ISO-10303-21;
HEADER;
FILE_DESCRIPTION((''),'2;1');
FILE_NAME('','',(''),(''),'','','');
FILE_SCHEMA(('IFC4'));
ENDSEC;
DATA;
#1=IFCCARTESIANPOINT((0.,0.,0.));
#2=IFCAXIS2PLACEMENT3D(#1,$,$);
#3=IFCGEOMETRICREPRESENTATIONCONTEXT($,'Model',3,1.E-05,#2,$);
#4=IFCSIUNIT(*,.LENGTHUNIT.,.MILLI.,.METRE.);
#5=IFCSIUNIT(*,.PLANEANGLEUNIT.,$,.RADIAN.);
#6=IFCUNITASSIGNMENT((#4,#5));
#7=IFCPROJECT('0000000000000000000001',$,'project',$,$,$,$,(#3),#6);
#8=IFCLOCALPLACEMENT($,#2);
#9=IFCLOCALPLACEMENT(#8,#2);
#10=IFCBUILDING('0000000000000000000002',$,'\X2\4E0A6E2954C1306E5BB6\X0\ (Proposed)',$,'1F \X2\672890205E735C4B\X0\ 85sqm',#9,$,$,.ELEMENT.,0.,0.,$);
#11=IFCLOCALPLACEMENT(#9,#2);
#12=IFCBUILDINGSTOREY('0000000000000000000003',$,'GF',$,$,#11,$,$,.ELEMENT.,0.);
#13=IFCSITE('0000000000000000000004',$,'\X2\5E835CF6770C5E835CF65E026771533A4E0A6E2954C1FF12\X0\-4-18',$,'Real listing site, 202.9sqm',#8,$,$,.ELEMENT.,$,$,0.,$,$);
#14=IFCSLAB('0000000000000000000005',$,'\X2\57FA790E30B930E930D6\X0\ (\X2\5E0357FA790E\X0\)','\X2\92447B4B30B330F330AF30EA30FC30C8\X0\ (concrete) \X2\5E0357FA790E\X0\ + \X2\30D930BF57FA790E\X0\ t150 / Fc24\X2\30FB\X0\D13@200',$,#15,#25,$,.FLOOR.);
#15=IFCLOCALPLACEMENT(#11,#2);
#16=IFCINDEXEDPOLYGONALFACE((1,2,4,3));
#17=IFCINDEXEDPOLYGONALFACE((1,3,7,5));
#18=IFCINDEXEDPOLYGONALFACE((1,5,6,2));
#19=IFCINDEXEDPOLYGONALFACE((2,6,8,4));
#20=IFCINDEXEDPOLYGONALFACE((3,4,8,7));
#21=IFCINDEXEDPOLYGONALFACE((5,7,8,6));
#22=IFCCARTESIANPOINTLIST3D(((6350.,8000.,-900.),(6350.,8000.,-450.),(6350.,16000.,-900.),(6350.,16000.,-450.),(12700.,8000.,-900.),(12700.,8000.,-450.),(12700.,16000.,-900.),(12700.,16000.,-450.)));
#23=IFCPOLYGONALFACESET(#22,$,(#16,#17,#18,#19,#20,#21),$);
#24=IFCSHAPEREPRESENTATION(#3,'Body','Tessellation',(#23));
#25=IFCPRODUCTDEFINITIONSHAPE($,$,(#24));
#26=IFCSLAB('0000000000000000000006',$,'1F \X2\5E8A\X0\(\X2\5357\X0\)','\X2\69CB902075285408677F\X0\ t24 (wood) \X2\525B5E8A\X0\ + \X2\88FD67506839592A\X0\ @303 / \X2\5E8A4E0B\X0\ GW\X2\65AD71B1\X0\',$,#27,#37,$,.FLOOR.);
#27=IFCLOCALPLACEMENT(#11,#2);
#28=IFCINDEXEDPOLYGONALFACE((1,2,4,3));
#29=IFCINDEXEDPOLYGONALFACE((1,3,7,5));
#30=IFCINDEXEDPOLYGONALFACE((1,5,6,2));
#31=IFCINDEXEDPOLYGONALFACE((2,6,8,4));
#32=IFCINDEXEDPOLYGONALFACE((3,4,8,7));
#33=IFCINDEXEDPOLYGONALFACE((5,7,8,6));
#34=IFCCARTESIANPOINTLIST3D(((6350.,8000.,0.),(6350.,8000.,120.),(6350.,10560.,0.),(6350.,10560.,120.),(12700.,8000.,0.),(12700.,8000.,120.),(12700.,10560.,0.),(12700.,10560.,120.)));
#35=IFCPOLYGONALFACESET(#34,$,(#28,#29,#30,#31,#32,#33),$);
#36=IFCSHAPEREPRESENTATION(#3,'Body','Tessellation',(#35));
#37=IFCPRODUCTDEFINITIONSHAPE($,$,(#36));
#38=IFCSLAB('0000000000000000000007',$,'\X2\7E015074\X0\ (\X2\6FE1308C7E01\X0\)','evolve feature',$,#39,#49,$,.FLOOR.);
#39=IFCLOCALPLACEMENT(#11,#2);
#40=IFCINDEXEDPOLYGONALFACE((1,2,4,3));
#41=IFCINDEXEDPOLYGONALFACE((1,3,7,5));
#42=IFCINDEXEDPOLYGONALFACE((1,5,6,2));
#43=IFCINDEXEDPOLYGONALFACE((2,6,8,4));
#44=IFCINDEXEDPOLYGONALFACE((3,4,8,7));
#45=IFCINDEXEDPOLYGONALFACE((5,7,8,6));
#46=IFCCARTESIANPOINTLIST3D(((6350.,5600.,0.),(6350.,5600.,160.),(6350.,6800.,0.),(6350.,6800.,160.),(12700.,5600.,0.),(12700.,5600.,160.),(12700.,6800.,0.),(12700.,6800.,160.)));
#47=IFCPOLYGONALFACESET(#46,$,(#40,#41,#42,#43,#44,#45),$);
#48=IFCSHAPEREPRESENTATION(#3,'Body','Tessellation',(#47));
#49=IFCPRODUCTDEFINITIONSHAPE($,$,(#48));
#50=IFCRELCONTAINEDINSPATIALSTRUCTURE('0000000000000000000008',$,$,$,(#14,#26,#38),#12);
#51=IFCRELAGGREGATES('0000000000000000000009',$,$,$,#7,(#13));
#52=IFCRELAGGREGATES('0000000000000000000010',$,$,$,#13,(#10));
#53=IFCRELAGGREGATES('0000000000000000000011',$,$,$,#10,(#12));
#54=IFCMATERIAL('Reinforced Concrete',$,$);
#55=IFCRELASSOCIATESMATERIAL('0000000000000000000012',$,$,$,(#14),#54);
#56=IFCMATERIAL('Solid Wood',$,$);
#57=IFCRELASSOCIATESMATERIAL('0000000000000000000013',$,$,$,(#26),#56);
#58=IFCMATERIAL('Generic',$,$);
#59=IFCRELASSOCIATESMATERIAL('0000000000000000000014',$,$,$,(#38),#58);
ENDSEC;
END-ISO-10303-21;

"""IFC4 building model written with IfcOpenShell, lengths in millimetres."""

from ifc_helpers import new_model, si_unit, frame, frame_2d, origin, place, context, project, spatial, rectangle, extrude, material, element, save


model = new_model("IFC4")

# Units and contexts
model_context = context("Model", 3, precision=1e-05, world=origin())
ifc_project = project(units=[si_unit("LENGTHUNIT", "METRE", prefix="MILLI"), si_unit("PLANEANGLEUNIT", "RADIAN")], contexts=[model_context])

# Site, building, storey
site_placement = place(None, origin())
site = spatial("IfcSite", under=ifc_project, at=site_placement, Name="広島県広島市東区上温品２-4-18", ObjectType="Real listing site, 202.9sqm", CompositionType="ELEMENT", RefElevation=0.0)
building_placement = place(site_placement, origin())
building = spatial("IfcBuilding", under=site, at=building_placement, Name="上温品の家 (Proposed)", ObjectType="1F 木造平屋 85sqm", CompositionType="ELEMENT", ElevationOfRefHeight=0.0, ElevationOfTerrain=0.0)
storey_placement = place(building_placement, origin())
storey = spatial("IfcBuildingStorey", under=building, at=storey_placement, Name="GF", CompositionType="ELEMENT", Elevation=0.0)

# Slabs
ifc_material_1 = material(Name="Reinforced Concrete")
slab_1_placement = place(storey_placement, frame((3175.0, 4000.0, -450.0)))
element("IfcSlab", 1, at=slab_1_placement, inside=storey, material=ifc_material_1, Name="基礎スラブ (布基礎)", Description="鉄筋コンクリート (concrete) 布基礎 + ベタ基礎 t150 / Fc24・D13@200", PredefinedType="FLOOR", context=model_context, shape_type="SweptSolid", body=[
    extrude(rectangle(XDim=6350.0, YDim=8000.0, at=frame_2d((3175.0, 4000.0))), frame((3175.0, 4000.0, -450.0)), (0.0, 0.0, 1.0), 450.0),
])
ifc_material_2 = material(Name="Solid Wood")
slab_2_placement = place(storey_placement, frame((3175.0, 4000.0, 0.0)))
element("IfcSlab", 2, at=slab_2_placement, inside=storey, material=ifc_material_2, Name="1F 床(南)", Description="構造用合板 t24 (wood) 剛床 + 製材根太 @303 / 床下 GW断熱", PredefinedType="FLOOR", context=model_context, shape_type="SweptSolid", body=[
    extrude(rectangle(XDim=6350.0, YDim=2560.0, at=frame_2d((3175.0, 1280.0))), frame((3175.0, 4000.0, 0.0)), (0.0, 0.0, 1.0), 120.0),
])
ifc_material_3 = material(Name="Generic")
slab_3_placement = place(storey_placement, frame((3175.0, 2800.0, 0.0)))
element("IfcSlab", 3, at=slab_3_placement, inside=storey, material=ifc_material_3, Name="縁側 (濡れ縁)", Description="evolve feature", PredefinedType="FLOOR", context=model_context, shape_type="SweptSolid", body=[
    extrude(rectangle(XDim=6350.0, YDim=1200.0, at=frame_2d((3175.0, 600.0))), frame((3175.0, 2800.0, 0.0)), (0.0, 0.0, 1.0), 160.0),
])

save(model, "model.ifc")
